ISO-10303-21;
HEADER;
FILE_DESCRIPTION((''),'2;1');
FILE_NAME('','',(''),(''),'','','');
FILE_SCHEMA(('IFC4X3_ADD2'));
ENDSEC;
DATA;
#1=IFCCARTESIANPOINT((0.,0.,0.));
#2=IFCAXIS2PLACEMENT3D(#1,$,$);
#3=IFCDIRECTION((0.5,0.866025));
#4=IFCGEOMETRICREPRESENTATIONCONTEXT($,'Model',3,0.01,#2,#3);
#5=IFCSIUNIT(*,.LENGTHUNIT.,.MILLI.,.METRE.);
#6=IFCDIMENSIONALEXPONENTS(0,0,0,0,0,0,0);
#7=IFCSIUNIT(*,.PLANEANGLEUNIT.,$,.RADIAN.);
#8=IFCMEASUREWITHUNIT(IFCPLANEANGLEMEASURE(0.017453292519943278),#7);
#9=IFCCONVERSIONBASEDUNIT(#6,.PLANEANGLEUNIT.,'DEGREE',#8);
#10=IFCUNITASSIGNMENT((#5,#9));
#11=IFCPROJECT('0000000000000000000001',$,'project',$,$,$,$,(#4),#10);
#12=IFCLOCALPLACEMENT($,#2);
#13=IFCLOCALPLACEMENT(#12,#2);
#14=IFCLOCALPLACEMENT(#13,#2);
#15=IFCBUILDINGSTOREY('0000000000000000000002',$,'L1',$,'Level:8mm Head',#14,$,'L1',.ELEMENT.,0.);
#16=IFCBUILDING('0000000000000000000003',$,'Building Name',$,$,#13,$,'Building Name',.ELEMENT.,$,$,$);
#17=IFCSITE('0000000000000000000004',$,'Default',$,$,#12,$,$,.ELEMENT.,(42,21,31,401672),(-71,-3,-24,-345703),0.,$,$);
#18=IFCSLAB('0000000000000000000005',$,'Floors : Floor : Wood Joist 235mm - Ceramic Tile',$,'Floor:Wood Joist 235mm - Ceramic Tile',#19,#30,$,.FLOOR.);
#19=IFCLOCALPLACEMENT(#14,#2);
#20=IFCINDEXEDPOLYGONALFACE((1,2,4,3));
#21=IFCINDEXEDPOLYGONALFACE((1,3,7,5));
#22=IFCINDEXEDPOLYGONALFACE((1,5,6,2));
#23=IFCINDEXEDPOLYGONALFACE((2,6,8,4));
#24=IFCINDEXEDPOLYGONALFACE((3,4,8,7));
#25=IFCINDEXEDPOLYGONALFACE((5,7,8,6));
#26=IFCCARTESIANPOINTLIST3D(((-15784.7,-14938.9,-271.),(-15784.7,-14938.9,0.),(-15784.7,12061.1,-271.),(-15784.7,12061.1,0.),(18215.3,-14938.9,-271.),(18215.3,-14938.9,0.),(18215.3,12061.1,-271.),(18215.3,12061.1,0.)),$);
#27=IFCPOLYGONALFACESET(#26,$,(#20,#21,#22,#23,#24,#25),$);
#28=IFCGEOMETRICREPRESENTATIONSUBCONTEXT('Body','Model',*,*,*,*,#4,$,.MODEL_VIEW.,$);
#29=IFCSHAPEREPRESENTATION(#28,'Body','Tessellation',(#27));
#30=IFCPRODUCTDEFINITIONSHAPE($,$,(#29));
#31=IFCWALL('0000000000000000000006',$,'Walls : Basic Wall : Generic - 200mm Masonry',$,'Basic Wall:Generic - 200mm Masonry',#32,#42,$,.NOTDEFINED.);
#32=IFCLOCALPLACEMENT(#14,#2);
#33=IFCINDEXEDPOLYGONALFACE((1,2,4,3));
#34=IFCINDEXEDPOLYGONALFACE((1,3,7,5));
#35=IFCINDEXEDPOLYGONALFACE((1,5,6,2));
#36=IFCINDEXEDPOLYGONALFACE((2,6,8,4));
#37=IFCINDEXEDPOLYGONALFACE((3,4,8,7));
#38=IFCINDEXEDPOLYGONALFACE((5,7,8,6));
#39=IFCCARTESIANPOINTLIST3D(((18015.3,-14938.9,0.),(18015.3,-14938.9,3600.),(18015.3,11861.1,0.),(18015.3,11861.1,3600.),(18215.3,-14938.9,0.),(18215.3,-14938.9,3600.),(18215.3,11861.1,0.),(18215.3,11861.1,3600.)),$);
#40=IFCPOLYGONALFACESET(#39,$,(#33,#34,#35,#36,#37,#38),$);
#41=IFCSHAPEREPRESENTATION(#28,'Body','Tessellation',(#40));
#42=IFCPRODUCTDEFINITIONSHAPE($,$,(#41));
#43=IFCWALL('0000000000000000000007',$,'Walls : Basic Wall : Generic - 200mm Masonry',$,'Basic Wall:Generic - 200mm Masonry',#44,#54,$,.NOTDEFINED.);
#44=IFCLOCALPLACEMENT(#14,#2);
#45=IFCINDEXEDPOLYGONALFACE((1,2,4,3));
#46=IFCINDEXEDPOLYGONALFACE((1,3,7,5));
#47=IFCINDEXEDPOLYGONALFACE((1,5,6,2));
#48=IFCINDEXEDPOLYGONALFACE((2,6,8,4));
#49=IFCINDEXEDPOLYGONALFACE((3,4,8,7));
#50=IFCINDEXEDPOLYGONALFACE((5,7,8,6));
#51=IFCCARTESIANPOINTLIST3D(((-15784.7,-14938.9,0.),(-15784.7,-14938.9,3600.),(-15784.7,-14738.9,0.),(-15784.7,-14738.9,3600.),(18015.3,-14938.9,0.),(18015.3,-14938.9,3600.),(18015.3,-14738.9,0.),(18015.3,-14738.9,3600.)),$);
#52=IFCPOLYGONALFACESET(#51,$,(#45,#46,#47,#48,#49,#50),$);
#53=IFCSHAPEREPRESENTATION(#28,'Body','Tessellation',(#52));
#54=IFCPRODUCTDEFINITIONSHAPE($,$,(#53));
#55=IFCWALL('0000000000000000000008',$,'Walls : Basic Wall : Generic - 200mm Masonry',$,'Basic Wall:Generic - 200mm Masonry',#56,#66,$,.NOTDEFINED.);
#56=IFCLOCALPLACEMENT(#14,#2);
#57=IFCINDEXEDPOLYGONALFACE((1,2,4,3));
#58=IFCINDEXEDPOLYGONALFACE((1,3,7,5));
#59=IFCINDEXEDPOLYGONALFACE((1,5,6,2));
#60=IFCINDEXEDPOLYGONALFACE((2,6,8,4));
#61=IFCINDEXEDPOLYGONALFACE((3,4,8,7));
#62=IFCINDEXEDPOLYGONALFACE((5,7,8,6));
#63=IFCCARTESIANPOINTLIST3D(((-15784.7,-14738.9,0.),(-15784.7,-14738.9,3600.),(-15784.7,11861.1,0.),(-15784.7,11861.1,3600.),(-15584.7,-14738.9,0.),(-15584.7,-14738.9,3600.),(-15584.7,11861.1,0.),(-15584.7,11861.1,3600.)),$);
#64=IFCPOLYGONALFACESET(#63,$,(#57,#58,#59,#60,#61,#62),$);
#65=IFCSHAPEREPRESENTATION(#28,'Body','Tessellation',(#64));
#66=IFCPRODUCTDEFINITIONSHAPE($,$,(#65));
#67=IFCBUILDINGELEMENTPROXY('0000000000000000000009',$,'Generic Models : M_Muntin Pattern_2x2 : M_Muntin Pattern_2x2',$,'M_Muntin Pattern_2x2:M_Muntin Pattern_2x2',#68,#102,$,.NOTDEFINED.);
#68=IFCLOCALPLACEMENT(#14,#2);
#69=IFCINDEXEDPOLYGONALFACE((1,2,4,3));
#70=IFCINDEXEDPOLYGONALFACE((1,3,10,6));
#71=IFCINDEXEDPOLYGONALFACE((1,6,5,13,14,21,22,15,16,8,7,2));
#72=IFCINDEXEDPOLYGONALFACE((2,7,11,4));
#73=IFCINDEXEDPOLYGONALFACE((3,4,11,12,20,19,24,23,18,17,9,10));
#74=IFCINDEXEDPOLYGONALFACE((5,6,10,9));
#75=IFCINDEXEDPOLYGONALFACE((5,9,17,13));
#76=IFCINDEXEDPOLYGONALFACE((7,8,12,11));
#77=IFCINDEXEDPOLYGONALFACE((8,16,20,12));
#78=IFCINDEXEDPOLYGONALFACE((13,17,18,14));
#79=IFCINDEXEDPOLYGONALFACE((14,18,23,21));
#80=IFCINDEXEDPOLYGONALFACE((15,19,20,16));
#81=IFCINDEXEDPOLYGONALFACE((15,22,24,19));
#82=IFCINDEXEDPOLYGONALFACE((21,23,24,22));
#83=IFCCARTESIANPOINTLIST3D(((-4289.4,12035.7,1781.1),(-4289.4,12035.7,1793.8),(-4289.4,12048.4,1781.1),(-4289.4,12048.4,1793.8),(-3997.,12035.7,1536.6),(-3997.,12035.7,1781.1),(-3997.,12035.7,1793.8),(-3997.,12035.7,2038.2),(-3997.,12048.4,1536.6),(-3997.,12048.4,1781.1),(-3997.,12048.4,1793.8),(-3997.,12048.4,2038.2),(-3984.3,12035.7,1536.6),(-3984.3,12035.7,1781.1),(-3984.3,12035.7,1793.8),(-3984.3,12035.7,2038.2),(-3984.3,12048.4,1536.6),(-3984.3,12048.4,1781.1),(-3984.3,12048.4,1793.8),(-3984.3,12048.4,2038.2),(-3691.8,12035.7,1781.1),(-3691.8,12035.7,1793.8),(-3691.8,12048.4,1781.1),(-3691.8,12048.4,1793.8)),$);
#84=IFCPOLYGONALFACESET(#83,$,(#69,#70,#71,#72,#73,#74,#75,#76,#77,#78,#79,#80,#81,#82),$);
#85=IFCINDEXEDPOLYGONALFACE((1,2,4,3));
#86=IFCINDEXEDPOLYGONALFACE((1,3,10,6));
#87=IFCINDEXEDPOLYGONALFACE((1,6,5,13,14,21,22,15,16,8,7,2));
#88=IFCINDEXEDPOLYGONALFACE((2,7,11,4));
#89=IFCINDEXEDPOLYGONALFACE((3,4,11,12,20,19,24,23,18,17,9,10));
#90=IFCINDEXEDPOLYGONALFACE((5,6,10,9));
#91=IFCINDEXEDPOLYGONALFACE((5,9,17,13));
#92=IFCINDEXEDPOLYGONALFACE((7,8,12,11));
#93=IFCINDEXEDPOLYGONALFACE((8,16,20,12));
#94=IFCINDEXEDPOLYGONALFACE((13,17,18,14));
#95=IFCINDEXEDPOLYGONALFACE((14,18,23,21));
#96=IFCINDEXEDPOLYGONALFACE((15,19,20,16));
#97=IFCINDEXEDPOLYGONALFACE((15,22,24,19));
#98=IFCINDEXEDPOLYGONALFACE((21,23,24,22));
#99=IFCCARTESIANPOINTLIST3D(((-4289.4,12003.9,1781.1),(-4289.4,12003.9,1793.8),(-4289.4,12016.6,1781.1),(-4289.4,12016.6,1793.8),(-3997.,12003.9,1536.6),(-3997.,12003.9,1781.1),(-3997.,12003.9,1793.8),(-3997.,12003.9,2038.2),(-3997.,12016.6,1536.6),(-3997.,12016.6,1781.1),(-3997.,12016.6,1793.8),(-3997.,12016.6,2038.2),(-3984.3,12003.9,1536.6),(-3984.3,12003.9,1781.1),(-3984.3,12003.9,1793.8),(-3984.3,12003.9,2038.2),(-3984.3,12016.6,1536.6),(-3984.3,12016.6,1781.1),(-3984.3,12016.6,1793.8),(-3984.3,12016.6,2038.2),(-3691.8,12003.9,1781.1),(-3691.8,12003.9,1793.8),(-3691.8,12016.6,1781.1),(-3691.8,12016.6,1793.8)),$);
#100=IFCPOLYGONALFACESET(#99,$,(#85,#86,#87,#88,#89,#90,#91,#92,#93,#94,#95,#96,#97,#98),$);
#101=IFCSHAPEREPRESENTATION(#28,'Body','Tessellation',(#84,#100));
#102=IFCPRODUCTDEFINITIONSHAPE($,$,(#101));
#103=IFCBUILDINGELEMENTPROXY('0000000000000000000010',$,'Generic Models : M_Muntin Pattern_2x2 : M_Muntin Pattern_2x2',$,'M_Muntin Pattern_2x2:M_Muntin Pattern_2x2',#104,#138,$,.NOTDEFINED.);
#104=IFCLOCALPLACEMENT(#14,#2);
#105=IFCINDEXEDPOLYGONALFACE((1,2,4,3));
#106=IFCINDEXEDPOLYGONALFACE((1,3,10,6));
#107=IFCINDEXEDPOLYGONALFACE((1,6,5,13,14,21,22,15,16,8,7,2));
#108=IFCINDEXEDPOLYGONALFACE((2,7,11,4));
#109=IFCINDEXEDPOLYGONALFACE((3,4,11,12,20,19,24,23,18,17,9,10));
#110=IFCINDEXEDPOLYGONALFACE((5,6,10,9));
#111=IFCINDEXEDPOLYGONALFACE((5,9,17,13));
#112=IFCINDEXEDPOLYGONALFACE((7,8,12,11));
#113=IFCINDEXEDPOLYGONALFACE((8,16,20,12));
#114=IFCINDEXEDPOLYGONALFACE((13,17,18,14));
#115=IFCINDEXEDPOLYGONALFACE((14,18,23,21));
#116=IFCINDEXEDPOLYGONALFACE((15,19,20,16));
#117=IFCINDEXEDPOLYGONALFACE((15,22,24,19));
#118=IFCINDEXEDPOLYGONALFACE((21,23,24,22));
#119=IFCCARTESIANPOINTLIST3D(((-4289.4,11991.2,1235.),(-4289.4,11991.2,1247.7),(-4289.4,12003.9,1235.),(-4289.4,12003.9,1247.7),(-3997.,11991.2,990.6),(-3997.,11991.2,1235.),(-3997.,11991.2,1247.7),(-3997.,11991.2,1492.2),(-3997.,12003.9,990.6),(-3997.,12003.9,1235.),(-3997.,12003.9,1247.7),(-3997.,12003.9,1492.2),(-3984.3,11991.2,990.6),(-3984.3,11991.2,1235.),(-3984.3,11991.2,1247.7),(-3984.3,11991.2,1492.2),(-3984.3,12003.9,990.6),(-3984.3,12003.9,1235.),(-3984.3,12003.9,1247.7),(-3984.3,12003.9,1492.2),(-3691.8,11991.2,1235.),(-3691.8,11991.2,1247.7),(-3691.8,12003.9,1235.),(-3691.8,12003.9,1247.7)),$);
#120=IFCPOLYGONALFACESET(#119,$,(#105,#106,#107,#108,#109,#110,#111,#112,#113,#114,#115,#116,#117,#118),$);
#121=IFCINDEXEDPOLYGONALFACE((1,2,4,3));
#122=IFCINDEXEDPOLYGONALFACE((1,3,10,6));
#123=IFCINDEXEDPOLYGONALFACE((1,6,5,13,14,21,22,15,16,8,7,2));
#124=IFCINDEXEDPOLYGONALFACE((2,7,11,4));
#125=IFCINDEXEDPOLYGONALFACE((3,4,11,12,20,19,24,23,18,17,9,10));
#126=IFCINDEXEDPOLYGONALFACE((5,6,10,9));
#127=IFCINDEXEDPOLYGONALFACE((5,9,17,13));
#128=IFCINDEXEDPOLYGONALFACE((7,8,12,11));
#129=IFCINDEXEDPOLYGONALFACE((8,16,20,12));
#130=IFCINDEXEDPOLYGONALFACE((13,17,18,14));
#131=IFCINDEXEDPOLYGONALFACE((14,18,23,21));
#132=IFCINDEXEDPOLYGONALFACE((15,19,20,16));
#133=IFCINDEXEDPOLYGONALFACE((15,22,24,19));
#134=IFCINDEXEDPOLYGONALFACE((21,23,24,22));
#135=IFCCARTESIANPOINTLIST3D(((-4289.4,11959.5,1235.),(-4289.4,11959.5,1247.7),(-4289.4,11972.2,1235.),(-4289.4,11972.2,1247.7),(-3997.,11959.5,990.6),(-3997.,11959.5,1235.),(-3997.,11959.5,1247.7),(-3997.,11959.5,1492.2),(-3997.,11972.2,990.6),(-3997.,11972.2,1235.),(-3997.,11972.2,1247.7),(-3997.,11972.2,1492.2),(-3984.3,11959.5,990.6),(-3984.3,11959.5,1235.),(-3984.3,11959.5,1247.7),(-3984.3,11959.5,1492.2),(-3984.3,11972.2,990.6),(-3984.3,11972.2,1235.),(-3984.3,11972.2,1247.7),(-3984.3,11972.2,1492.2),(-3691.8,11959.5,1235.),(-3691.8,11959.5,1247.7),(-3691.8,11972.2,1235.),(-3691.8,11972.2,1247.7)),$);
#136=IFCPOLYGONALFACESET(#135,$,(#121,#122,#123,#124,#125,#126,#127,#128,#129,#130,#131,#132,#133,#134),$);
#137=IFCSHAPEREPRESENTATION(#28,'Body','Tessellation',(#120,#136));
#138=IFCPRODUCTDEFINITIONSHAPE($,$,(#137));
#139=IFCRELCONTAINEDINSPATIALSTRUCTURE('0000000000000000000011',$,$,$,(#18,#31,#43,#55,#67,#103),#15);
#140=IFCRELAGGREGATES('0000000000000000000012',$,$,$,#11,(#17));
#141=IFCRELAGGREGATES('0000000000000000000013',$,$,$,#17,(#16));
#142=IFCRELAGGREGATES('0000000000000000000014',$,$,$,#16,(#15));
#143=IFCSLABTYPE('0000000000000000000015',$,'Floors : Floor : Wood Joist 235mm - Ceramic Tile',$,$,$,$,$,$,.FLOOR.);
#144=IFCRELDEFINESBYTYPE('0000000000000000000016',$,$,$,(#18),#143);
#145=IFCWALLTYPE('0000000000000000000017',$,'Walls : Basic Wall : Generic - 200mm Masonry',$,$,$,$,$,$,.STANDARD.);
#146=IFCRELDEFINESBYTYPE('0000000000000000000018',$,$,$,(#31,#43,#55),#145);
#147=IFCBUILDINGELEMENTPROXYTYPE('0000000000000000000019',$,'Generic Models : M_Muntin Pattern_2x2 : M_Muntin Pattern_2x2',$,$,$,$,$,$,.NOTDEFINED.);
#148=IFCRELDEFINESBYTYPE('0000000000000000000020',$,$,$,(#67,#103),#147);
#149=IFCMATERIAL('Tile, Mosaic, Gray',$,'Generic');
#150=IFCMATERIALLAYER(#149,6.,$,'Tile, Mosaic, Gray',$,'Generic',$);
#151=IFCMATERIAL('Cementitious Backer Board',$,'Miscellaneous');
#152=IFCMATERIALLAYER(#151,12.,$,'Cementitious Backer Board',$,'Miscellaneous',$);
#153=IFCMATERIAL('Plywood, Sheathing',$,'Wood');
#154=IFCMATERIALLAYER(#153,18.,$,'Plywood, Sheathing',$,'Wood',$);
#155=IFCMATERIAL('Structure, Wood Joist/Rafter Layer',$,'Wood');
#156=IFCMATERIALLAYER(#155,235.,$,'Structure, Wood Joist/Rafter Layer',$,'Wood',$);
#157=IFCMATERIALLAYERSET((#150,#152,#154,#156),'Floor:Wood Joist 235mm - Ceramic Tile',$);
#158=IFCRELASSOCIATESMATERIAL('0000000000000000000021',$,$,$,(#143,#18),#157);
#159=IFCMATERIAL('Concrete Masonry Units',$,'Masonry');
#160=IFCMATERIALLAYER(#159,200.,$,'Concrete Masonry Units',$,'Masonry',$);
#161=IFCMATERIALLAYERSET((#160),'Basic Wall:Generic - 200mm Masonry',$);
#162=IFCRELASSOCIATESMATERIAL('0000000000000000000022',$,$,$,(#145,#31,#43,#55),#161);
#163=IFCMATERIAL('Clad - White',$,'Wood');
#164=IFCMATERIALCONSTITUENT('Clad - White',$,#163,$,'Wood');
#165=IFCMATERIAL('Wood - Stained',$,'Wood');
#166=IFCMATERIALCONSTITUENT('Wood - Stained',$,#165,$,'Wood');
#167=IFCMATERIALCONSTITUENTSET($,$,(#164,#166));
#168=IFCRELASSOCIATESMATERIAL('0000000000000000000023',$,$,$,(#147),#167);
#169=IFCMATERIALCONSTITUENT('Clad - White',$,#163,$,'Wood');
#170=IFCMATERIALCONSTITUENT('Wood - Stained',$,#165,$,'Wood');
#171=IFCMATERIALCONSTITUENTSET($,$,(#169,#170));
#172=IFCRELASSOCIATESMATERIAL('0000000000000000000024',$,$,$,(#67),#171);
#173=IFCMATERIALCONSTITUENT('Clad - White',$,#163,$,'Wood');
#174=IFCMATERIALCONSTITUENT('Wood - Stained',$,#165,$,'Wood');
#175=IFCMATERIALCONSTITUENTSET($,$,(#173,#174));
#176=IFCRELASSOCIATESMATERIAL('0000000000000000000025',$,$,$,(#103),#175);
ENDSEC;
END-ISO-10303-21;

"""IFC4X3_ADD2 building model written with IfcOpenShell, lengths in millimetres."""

from ifc_helpers import new_model, entity, si_unit, converted_unit, direction, frame, frame_2d, origin, origin_2d_with_axis, place, context, subcontext, project, spatial, polyline, rectangle, outline, extrude, source, transform, mapped, material, layer, layer_set, layer_usage, constituent, constituent_set, type_object, type_shapes, element, save


model = new_model("IFC4X3_ADD2")

# Units and contexts
model_context = context("Model", 3, precision=0.01, world=origin(), true_north=direction((0.5, 0.866025)))
body_context = subcontext(model_context, "Body", "Model", "MODEL_VIEW")
ifc_project = project(units=[si_unit("LENGTHUNIT", "METRE", prefix="MILLI"), converted_unit("PLANEANGLEUNIT", "DEGREE", entity("IfcPlaneAngleMeasure", 0.017453292519943278), si_unit("PLANEANGLEUNIT", "RADIAN"), dimensions=[0, 0, 0, 0, 0, 0, 0])], contexts=[model_context])

# Site, building, storey
site_placement = place(None, origin())
site = spatial("IfcSite", under=ifc_project, at=site_placement, Name="Default", CompositionType="ELEMENT", RefLatitude=(42, 21, 31, 401672), RefLongitude=(-71, -3, -24, -345703), RefElevation=0.0)
building_placement = place(site_placement, origin())
building = spatial("IfcBuilding", under=site, at=building_placement, Name="Building Name", LongName="Building Name", CompositionType="ELEMENT")
storey_placement = place(building_placement, origin())
storey = spatial("IfcBuildingStorey", under=building, at=storey_placement, Name="L1", ObjectType="Level:8mm Head", LongName="L1", CompositionType="ELEMENT", Elevation=0.0)

# Slab
ifc_material_1 = material(Name="Tile, Mosaic, Gray", Category="Generic")
ifc_layer_1 = layer(ifc_material_1, 6.0, Name="Tile, Mosaic, Gray", Category="Generic")
ifc_material_2 = material(Name="Cementitious Backer Board", Category="Miscellaneous")
ifc_layer_2 = layer(ifc_material_2, 12.0, Name="Cementitious Backer Board", Category="Miscellaneous")
ifc_material_3 = material(Name="Plywood, Sheathing", Category="Wood")
ifc_layer_3 = layer(ifc_material_3, 18.0, Name="Plywood, Sheathing", Category="Wood")
ifc_material_4 = material(Name="Structure, Wood Joist/Rafter Layer", Category="Wood")
ifc_layer_4 = layer(ifc_material_4, 235.0, Name="Structure, Wood Joist/Rafter Layer", Category="Wood")
ifc_layer_set_1 = layer_set([ifc_layer_1, ifc_layer_2, ifc_layer_3, ifc_layer_4], Name="Floor:Wood Joist 235mm - Ceramic Tile")
ifc_layer_usage = layer_usage(ifc_layer_set_1, "AXIS3", "POSITIVE", 0.0)
slab_type = type_object("IfcSlabType", Name="Floors : Floor : Wood Joist 235mm - Ceramic Tile", PredefinedType="FLOOR", material=ifc_layer_set_1)
slab_placement = place(storey_placement, origin())
element("IfcSlab", 1, at=slab_placement, inside=storey, type_object=slab_type, material=ifc_layer_usage, Name="Floors : Floor : Wood Joist 235mm - Ceramic Tile", ObjectType="Floor:Wood Joist 235mm - Ceramic Tile", PredefinedType="FLOOR", context=body_context, shape_type="SweptSolid", body=[
    extrude(rectangle(XDim=27000.0, YDim=34000.0, at=origin_2d_with_axis()), frame((1215.3, -1438.9, 0.0), z_axis=(0.0, 0.0, -1.0), x_axis=(0.0, 1.0, 0.0)), (0.0, 0.0, 1.0), 271.0),
])

# Shared definitions
ifc_material_5 = material(Name="Concrete Masonry Units", Category="Masonry")
ifc_layer_5 = layer(ifc_material_5, 200.0, Name="Concrete Masonry Units", Category="Masonry")
ifc_layer_set_2 = layer_set([ifc_layer_5], Name="Basic Wall:Generic - 200mm Masonry")
wall_type = type_object("IfcWallType", Name="Walls : Basic Wall : Generic - 200mm Masonry", PredefinedType="STANDARD", material=ifc_layer_set_2)
ifc_material_6 = material(Name="Wood - Stained", Category="Wood")

# Walls
wall_1_placement = place(storey_placement, frame((18115.3, 11861.1, 0.0), z_axis=(0.0, 0.0, 1.0), x_axis=(0.0, -1.0, 0.0)))
element("IfcWall", 2, at=wall_1_placement, inside=storey, type_object=wall_type, material=ifc_layer_set_2, Name="Walls : Basic Wall : Generic - 200mm Masonry", ObjectType="Basic Wall:Generic - 200mm Masonry", PredefinedType="NOTDEFINED", context=body_context, shape_type="SweptSolid", body=[
    extrude(rectangle(XDim=26800.0, YDim=200.0, at=frame_2d((13400.0, 0.0), x_axis=(-1.0, 0.0))), origin(), (0.0, 0.0, 1.0), 3600.0),
])
wall_2_placement = place(storey_placement, frame((18015.3, -14838.9, 0.0), z_axis=(0.0, 0.0, 1.0), x_axis=(-1.0, 0.0, 0.0)))
element("IfcWall", 3, at=wall_2_placement, inside=storey, type_object=wall_type, material=ifc_layer_set_2, Name="Walls : Basic Wall : Generic - 200mm Masonry", ObjectType="Basic Wall:Generic - 200mm Masonry", PredefinedType="NOTDEFINED", context=body_context, shape_type="SweptSolid", body=[
    extrude(rectangle(XDim=33800.0, YDim=200.0, at=frame_2d((16900.0, 0.0), x_axis=(-1.0, 0.0))), origin(), (0.0, 0.0, 1.0), 3600.0),
])
wall_3_placement = place(storey_placement, frame((-15684.7, -14738.9, 0.0), z_axis=(0.0, 0.0, 1.0), x_axis=(0.0, 1.0, 0.0)))
element("IfcWall", 4, at=wall_3_placement, inside=storey, type_object=wall_type, material=ifc_layer_set_2, Name="Walls : Basic Wall : Generic - 200mm Masonry", ObjectType="Basic Wall:Generic - 200mm Masonry", PredefinedType="NOTDEFINED", context=body_context, shape_type="SweptSolid", body=[
    extrude(rectangle(XDim=26600.0, YDim=200.0, at=frame_2d((13300.0, 0.0), x_axis=(-1.0, 0.0))), origin(), (0.0, 0.0, 1.0), 3600.0),
])

# Building element proxies
ifc_material_7 = material(Name="Clad - White", Category="Wood")
ifc_constituent_1 = constituent(ifc_material_7, Name="Clad - White", Category="Wood")
ifc_constituent_2 = constituent(ifc_material_6, Name="Wood - Stained", Category="Wood")
ifc_constituent_set_1 = constituent_set(constituents=[ifc_constituent_1, ifc_constituent_2])
ifc_constituent_3 = constituent(ifc_material_7, Name="Clad - White", Category="Wood")
ifc_constituent_4 = constituent(ifc_material_6, Name="Wood - Stained", Category="Wood")
ifc_constituent_set_2 = constituent_set(constituents=[ifc_constituent_3, ifc_constituent_4])
building_element_proxy_type_1 = type_object("IfcBuildingElementProxyType", Name="Generic Models : M_Muntin Pattern_2x2 : M_Muntin Pattern_2x2", PredefinedType="NOTDEFINED", material=ifc_constituent_set_2)
shared_shape_1 = source(origin(), body_context, "Body", "SweptSolid", [
    extrude(outline(polyline([(6.4, -6.4), (250.8, -6.4), (250.8, 6.3), (6.4, 6.3), (6.4, 298.8), (-6.3, 298.8), (-6.3, 6.3), (-250.8, 6.3), (-250.8, -6.4), (-6.3, -6.4), (-6.3, -298.8), (6.4, -298.8), (6.4, -6.4)])), frame((0.0, 9.5, 250.8), z_axis=(0.0, 1.0, 0.0), x_axis=(0.0, 0.0, 1.0)), (0.0, 0.0, 1.0), 12.7),
    extrude(outline(polyline([(6.4, -6.4), (250.8, -6.4), (250.8, 6.3), (6.4, 6.3), (6.4, 298.8), (-6.3, 298.8), (-6.3, 6.3), (-250.8, 6.3), (-250.8, -6.4), (-6.3, -6.4), (-6.3, -298.8), (6.4, -298.8), (6.4, -6.4)])), frame((0.0, -22.2, 250.8), z_axis=(0.0, 1.0, 0.0), x_axis=(0.0, 0.0, 1.0)), (0.0, 0.0, 1.0), 12.7),
])
type_shapes(building_element_proxy_type_1, [shared_shape_1])
proxy_1_placement = place(storey_placement, frame((-3990.6, 12026.1, 1536.6)))
element("IfcBuildingElementProxy", 5, at=proxy_1_placement, inside=storey, type_object=building_element_proxy_type_1, material=ifc_constituent_set_1, Name="Generic Models : M_Muntin Pattern_2x2 : M_Muntin Pattern_2x2", ObjectType="M_Muntin Pattern_2x2:M_Muntin Pattern_2x2", PredefinedType="NOTDEFINED", context=body_context, shape_type="MappedRepresentation", body=[
    mapped(shared_shape_1, transform((0.0, 0.0, 0.0), scale=1.0)),
])
ifc_constituent_5 = constituent(ifc_material_7, Name="Clad - White", Category="Wood")
ifc_constituent_6 = constituent(ifc_material_6, Name="Wood - Stained", Category="Wood")
ifc_constituent_set_3 = constituent_set(constituents=[ifc_constituent_5, ifc_constituent_6])
proxy_2_placement = place(storey_placement, frame((-3990.6, 11981.7, 990.6)))
element("IfcBuildingElementProxy", 6, at=proxy_2_placement, inside=storey, type_object=building_element_proxy_type_1, material=ifc_constituent_set_3, Name="Generic Models : M_Muntin Pattern_2x2 : M_Muntin Pattern_2x2", ObjectType="M_Muntin Pattern_2x2:M_Muntin Pattern_2x2", PredefinedType="NOTDEFINED", context=body_context, shape_type="MappedRepresentation", body=[
    mapped(shared_shape_1, transform((0.0, 0.0, 0.0), scale=1.0)),
])

save(model, "model.ifc")
